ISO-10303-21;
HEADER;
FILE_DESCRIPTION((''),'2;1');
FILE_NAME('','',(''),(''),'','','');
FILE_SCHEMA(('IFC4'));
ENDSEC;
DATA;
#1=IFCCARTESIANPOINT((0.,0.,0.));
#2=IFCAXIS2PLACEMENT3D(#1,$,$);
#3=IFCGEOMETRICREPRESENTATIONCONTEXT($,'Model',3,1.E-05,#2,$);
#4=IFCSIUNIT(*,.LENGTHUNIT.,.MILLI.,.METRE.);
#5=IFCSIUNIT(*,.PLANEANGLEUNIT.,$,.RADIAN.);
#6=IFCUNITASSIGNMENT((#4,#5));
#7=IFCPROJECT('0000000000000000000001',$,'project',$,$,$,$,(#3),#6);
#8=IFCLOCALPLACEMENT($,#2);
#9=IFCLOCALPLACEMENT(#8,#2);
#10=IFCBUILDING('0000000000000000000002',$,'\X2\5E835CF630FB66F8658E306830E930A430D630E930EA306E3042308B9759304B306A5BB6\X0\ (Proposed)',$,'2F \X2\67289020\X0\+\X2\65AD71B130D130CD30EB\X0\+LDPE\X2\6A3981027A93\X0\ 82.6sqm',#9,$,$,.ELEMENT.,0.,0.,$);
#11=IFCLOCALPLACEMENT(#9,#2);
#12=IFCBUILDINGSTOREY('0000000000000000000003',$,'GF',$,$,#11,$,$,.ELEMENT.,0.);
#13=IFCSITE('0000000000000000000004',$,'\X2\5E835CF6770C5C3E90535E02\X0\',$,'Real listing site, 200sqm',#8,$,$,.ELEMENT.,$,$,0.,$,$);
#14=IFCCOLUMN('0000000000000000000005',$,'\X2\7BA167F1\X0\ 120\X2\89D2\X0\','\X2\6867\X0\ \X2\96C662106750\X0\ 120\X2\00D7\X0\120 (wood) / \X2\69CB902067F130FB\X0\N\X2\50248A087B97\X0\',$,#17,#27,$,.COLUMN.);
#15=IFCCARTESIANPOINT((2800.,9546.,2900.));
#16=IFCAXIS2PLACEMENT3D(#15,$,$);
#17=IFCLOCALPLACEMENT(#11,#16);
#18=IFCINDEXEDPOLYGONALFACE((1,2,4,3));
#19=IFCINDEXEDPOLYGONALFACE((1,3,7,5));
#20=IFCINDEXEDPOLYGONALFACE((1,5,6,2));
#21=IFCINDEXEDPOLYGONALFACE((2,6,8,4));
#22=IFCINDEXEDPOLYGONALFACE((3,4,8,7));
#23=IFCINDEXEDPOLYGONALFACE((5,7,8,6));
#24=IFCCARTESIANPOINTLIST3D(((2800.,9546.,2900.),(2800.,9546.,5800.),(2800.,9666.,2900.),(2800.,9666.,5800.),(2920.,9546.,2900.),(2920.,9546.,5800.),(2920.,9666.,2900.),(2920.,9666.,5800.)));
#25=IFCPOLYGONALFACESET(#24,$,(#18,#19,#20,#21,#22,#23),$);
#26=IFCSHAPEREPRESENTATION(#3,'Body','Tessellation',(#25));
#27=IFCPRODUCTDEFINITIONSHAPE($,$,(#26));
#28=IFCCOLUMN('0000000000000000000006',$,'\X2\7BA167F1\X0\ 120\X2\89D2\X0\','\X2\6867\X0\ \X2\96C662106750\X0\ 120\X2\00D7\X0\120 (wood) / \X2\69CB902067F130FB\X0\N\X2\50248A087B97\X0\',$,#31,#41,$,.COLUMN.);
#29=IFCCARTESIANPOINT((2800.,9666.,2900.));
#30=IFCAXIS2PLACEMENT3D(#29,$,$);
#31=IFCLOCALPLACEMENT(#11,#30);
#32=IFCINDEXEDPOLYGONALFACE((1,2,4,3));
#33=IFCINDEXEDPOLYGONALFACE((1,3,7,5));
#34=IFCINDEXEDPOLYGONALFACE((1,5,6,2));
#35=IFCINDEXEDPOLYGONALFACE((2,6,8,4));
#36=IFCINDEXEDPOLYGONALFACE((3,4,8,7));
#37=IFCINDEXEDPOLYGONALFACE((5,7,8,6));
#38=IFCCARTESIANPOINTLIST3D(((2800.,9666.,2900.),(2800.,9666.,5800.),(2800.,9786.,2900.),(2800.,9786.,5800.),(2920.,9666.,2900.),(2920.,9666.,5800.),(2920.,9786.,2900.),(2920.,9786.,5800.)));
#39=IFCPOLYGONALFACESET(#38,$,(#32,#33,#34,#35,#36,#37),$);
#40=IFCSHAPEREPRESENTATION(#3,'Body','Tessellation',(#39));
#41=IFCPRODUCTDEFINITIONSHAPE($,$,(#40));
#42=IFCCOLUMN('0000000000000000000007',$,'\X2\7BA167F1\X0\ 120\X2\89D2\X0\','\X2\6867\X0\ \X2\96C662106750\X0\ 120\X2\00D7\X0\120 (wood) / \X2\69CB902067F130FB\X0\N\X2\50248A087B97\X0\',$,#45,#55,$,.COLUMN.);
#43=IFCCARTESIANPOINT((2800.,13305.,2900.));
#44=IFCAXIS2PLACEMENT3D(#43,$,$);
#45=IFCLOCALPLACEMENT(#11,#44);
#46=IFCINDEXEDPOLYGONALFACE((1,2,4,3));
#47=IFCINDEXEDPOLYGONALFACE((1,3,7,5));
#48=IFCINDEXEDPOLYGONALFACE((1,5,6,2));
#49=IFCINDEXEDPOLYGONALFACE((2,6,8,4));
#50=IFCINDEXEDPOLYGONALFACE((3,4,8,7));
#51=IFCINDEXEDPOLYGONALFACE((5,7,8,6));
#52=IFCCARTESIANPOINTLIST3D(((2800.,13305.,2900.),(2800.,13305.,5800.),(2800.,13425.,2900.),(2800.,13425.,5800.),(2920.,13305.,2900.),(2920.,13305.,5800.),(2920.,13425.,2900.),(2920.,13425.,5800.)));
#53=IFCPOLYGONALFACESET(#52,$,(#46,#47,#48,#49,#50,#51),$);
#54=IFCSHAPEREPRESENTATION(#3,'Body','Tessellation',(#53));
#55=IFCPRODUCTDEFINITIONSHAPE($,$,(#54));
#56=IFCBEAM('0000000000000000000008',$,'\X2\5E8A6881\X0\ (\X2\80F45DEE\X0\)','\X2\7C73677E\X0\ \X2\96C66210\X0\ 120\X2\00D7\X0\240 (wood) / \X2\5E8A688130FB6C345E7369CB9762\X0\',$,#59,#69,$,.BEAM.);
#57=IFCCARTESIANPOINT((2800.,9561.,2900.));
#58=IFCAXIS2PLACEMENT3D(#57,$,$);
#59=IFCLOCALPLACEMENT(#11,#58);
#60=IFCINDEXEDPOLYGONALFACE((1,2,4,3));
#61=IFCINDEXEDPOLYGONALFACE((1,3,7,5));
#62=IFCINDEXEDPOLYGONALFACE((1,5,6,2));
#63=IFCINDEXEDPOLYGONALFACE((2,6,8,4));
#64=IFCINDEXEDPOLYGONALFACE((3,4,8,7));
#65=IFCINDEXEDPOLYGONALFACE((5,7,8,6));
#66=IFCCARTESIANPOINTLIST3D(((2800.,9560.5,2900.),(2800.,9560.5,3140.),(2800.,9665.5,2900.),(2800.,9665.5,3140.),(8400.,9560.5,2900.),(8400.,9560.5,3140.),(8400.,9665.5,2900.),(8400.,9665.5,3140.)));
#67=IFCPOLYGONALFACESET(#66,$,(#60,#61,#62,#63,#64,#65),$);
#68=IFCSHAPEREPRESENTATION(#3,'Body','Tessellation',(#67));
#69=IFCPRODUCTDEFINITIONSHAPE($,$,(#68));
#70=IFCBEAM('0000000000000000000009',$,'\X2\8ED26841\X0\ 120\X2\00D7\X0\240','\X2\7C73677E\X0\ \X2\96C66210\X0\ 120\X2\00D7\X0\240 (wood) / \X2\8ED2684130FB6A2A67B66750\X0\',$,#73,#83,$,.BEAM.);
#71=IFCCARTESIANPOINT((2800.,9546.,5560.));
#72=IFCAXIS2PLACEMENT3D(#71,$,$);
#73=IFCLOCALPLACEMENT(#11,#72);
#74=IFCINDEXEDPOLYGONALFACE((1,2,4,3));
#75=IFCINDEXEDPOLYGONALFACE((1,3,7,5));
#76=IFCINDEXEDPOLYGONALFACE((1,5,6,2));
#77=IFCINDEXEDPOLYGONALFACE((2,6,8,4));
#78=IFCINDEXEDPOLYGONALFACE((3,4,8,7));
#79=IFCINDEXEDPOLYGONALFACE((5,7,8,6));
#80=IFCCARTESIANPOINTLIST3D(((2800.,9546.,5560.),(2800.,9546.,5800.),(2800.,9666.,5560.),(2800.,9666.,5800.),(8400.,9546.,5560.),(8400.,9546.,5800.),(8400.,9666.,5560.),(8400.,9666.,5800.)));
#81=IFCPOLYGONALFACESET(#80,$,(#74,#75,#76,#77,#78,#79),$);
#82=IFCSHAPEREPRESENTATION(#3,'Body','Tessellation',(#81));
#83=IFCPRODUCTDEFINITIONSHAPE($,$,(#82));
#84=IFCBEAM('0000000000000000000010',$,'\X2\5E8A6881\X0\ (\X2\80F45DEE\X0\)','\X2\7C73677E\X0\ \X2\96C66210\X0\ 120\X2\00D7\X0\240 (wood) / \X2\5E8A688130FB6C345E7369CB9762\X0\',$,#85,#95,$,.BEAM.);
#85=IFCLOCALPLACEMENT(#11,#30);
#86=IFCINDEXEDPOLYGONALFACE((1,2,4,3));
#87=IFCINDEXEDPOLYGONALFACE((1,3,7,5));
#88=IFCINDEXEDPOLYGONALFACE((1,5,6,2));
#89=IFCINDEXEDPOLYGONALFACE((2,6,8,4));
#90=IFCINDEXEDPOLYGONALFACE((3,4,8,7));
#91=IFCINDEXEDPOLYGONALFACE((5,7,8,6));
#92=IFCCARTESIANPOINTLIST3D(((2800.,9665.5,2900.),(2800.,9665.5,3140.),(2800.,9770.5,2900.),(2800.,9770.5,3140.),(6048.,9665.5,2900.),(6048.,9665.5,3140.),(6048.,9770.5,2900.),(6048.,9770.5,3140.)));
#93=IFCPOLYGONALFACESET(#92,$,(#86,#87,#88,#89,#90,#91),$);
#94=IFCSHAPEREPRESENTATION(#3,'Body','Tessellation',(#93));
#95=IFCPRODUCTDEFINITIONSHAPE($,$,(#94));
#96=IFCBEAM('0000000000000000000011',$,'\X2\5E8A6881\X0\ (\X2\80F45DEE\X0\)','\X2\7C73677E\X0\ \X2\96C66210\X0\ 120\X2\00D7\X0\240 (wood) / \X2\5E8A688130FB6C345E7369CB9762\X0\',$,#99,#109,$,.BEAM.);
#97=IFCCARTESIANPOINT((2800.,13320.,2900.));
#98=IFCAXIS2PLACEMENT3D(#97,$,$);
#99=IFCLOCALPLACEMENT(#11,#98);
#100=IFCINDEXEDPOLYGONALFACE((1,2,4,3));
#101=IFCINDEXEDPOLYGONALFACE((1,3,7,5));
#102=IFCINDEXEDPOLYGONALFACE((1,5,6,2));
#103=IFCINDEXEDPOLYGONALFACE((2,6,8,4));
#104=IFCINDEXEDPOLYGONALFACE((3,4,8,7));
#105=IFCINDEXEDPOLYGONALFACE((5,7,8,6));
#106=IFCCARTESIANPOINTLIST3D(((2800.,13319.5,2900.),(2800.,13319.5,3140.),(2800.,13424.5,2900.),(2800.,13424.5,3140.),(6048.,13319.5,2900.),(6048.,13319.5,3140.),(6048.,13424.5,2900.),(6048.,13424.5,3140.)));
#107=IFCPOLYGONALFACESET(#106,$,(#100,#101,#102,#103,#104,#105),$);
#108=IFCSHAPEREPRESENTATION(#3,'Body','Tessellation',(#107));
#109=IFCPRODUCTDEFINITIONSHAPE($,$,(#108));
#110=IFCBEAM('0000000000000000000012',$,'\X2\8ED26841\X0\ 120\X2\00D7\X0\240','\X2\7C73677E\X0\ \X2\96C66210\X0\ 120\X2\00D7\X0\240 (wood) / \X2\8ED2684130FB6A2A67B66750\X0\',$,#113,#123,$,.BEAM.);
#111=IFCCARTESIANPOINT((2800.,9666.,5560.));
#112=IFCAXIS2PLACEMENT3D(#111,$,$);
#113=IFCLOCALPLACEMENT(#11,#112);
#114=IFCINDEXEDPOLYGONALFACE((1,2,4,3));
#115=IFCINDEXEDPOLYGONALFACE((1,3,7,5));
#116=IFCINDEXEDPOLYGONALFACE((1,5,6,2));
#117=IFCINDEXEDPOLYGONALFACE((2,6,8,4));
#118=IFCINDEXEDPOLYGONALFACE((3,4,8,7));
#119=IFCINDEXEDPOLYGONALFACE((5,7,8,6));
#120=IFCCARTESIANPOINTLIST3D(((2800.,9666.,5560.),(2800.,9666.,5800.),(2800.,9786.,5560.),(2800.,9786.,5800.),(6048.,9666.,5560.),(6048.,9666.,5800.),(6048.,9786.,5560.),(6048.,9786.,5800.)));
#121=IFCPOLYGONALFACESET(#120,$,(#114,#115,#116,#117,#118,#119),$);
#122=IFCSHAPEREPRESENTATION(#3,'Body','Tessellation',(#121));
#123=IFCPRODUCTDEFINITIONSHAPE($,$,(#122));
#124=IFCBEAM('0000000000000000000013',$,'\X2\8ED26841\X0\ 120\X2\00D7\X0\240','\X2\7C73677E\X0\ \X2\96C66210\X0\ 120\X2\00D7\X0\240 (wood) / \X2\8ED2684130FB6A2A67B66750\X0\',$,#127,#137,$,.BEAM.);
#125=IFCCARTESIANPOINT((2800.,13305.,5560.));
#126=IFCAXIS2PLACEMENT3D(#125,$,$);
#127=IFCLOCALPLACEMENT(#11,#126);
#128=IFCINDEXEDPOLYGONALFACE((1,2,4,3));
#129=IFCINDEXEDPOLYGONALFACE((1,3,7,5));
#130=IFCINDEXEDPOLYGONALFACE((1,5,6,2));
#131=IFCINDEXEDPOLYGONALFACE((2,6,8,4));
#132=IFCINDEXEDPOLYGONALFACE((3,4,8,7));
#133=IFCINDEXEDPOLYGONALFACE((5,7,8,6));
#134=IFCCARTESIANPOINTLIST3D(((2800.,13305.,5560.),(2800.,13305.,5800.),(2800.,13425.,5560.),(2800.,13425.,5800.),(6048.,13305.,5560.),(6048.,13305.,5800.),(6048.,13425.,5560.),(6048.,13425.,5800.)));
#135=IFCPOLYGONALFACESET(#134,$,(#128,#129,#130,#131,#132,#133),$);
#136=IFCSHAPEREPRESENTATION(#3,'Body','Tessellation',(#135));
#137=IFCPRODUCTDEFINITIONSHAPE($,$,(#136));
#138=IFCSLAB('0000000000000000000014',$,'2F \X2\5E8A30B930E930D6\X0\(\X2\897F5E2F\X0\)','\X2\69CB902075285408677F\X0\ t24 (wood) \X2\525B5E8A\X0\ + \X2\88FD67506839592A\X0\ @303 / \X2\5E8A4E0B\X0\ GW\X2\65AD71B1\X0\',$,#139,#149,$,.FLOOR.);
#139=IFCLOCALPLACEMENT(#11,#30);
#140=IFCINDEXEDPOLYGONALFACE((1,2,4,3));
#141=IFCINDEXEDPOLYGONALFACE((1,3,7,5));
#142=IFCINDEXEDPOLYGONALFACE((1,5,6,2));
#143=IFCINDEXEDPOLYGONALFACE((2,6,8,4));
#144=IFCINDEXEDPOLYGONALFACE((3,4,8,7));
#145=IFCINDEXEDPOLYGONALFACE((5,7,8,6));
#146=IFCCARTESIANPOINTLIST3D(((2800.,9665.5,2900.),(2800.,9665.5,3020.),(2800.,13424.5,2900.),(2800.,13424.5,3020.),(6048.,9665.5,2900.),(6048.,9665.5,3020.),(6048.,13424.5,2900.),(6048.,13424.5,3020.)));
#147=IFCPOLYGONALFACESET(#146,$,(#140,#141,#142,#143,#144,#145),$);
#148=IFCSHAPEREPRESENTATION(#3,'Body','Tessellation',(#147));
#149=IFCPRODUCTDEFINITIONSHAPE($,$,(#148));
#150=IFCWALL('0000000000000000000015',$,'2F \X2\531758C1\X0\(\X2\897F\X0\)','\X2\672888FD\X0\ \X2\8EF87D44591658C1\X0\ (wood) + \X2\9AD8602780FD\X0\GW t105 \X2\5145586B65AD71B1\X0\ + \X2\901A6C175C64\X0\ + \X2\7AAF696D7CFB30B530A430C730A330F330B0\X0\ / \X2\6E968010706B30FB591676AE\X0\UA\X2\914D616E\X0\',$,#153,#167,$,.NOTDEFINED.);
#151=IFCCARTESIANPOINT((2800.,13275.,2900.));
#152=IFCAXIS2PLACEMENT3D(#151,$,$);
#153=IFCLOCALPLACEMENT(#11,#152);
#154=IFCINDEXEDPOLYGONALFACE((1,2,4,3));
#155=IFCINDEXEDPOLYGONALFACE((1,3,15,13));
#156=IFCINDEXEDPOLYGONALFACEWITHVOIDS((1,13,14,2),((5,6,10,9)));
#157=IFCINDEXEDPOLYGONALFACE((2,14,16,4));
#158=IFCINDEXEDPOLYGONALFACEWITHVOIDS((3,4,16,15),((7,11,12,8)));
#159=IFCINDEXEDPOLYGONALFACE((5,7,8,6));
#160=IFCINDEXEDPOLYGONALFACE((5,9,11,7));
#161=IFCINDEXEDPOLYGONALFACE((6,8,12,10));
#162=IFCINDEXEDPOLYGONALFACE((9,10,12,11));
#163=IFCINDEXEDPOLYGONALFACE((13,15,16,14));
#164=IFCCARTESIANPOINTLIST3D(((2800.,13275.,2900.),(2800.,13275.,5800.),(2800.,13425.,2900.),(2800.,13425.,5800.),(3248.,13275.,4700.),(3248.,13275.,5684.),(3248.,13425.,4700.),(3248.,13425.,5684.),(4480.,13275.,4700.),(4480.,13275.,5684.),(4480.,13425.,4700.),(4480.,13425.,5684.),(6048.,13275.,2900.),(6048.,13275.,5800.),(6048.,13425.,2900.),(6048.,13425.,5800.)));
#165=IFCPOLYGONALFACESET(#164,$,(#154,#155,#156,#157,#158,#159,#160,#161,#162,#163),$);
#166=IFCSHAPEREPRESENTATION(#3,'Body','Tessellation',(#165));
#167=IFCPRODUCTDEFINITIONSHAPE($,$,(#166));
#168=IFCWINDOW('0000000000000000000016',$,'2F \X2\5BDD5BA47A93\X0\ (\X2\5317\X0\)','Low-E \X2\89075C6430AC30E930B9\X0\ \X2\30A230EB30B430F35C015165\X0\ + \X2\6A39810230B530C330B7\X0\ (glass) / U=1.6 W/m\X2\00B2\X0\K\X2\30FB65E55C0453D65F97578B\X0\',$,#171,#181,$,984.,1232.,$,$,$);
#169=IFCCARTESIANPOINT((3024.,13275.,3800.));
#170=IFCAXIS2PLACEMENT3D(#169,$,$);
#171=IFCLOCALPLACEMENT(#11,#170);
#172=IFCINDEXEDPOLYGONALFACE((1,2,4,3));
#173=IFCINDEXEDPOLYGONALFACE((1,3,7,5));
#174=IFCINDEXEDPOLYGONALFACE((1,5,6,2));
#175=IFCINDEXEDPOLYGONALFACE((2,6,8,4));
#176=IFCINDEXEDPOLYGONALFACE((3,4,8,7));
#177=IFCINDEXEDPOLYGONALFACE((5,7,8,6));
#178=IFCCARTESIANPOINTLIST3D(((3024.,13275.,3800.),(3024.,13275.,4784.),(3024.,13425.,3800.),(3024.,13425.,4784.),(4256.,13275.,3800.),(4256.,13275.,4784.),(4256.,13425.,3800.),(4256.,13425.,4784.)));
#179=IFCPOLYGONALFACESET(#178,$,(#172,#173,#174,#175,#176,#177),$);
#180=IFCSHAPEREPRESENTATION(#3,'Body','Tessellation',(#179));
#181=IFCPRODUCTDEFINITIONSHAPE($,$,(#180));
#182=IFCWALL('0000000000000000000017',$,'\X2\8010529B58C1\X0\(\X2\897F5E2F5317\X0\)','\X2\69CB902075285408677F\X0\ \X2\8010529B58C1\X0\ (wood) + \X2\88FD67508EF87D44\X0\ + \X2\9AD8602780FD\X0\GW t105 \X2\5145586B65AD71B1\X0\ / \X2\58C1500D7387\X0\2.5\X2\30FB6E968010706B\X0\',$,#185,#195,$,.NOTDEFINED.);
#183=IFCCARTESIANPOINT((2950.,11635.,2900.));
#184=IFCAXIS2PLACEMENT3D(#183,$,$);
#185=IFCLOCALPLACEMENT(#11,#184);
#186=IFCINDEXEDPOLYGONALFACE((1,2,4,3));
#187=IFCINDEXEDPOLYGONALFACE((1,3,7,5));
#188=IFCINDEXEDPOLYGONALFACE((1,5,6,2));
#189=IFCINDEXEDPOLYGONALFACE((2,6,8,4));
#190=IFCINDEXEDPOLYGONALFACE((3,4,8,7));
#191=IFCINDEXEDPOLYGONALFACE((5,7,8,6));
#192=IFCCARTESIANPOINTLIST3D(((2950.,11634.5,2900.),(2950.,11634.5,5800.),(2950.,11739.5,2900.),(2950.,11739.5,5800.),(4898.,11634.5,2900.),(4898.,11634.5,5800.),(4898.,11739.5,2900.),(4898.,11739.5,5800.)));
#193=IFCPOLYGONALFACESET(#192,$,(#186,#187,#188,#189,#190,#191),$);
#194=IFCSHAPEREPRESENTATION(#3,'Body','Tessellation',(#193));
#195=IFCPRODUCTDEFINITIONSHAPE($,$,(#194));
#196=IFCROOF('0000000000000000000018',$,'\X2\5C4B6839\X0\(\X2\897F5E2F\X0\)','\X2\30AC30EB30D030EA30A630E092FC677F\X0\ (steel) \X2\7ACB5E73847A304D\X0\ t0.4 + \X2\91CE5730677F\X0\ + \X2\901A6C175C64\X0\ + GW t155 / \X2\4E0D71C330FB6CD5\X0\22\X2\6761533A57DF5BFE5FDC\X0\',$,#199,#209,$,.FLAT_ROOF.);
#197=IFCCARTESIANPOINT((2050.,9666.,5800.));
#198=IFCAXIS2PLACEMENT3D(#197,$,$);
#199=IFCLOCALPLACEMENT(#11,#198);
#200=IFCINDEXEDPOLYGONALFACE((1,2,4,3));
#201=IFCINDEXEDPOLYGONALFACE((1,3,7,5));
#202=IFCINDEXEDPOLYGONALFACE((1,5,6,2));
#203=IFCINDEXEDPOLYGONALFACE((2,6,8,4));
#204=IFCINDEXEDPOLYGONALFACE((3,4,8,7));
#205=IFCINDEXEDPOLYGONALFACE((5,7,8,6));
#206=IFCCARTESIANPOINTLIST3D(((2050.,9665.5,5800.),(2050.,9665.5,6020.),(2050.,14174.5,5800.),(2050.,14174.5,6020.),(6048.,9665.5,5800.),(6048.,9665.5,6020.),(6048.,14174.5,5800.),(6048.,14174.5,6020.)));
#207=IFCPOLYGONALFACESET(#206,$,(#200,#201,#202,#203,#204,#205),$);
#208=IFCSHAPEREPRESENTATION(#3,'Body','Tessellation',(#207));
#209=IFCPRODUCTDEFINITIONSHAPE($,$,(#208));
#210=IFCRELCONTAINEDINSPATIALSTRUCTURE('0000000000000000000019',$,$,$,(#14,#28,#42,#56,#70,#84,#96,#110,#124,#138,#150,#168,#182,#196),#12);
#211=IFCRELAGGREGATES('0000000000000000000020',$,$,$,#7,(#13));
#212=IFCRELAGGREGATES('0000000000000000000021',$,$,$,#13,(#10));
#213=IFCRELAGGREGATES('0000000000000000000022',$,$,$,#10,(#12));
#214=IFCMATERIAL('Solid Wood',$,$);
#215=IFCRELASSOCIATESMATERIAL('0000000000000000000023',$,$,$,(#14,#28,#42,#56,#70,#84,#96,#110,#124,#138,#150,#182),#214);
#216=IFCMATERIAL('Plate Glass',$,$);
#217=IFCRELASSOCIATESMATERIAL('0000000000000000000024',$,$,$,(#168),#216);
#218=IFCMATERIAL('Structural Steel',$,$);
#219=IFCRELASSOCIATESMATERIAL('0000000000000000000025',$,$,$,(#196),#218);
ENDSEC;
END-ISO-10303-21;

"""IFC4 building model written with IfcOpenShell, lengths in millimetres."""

from ifc_helpers import new_model, si_unit, frame, frame_2d, origin, place, context, project, spatial, rectangle, extrude, material, element, fill, save


model = new_model("IFC4")

# Units and contexts
model_context = context("Model", 3, precision=1e-05, world=origin())
ifc_project = project(units=[si_unit("LENGTHUNIT", "METRE", prefix="MILLI"), si_unit("PLANEANGLEUNIT", "RADIAN")], contexts=[model_context])

# Site, building, storey
site_placement = place(None, origin())
site = spatial("IfcSite", under=ifc_project, at=site_placement, Name="広島県尾道市", ObjectType="Real listing site, 200sqm", CompositionType="ELEMENT", RefElevation=0.0)
building_placement = place(site_placement, origin())
building = spatial("IfcBuilding", under=site, at=building_placement, Name="広島・書斎とライブラリのある静かな家 (Proposed)", ObjectType="2F 木造+断熱パネル+LDPE樹脂窓 82.6sqm", CompositionType="ELEMENT", ElevationOfRefHeight=0.0, ElevationOfTerrain=0.0)
storey_placement = place(building_placement, origin())
storey = spatial("IfcBuildingStorey", under=building, at=storey_placement, Name="GF", CompositionType="ELEMENT", Elevation=0.0)

# Columns
ifc_material_1 = material(Name="Solid Wood")
column_1_placement = place(storey_placement, frame((2800.0, 9546.0, 2900.0)))
element("IfcColumn", 1, at=column_1_placement, inside=storey, material=ifc_material_1, Name="管柱 120角", Description="桧 集成材 120×120 (wood) / 構造柱・N値計算", PredefinedType="COLUMN", context=model_context, shape_type="SweptSolid", body=[
    extrude(rectangle(XDim=120.0, YDim=120.0, at=frame_2d((60.0, 60.0))), frame((2800.0, 9546.0, 2900.0)), (0.0, 0.0, 1.0), 2900.0),
])
column_2_placement = place(storey_placement, frame((2800.0, 9666.0, 2900.0)))
element("IfcColumn", 2, at=column_2_placement, inside=storey, material=ifc_material_1, Name="管柱 120角", Description="桧 集成材 120×120 (wood) / 構造柱・N値計算", PredefinedType="COLUMN", context=model_context, shape_type="SweptSolid", body=[
    extrude(rectangle(XDim=120.0, YDim=120.0, at=frame_2d((60.0, 60.0))), frame((2800.0, 9666.0, 2900.0)), (0.0, 0.0, 1.0), 2900.0),
])
column_3_placement = place(storey_placement, frame((2800.0, 13305.0, 2900.0)))
element("IfcColumn", 3, at=column_3_placement, inside=storey, material=ifc_material_1, Name="管柱 120角", Description="桧 集成材 120×120 (wood) / 構造柱・N値計算", PredefinedType="COLUMN", context=model_context, shape_type="SweptSolid", body=[
    extrude(rectangle(XDim=120.0, YDim=120.0, at=frame_2d((60.0, 60.0))), frame((2800.0, 13305.0, 2900.0)), (0.0, 0.0, 1.0), 2900.0),
])

# Beams
beam_1_placement = place(storey_placement, frame((2800.0, 9561.0, 2900.0)))
element("IfcBeam", 4, at=beam_1_placement, inside=storey, material=ifc_material_1, Name="床梁 (胴差)", Description="米松 集成 120×240 (wood) / 床梁・水平構面", PredefinedType="BEAM", context=model_context, shape_type="SweptSolid", body=[
    extrude(rectangle(XDim=5600.0, YDim=105.0, at=frame_2d((2800.0, 52.0))), frame((2800.0, 9561.0, 2900.0)), (0.0, 0.0, 1.0), 240.0),
])
beam_2_placement = place(storey_placement, frame((2800.0, 9546.0, 5560.0)))
element("IfcBeam", 5, at=beam_2_placement, inside=storey, material=ifc_material_1, Name="軒桁 120×240", Description="米松 集成 120×240 (wood) / 軒桁・横架材", PredefinedType="BEAM", context=model_context, shape_type="SweptSolid", body=[
    extrude(rectangle(XDim=5600.0, YDim=120.0, at=frame_2d((2800.0, 60.0))), frame((2800.0, 9546.0, 5560.0)), (0.0, 0.0, 1.0), 240.0),
])
beam_3_placement = place(storey_placement, frame((2800.0, 9666.0, 2900.0)))
element("IfcBeam", 6, at=beam_3_placement, inside=storey, material=ifc_material_1, Name="床梁 (胴差)", Description="米松 集成 120×240 (wood) / 床梁・水平構面", PredefinedType="BEAM", context=model_context, shape_type="SweptSolid", body=[
    extrude(rectangle(XDim=3248.0, YDim=105.0, at=frame_2d((1624.0, 52.0))), frame((2800.0, 9666.0, 2900.0)), (0.0, 0.0, 1.0), 240.0),
])
beam_4_placement = place(storey_placement, frame((2800.0, 13320.0, 2900.0)))
element("IfcBeam", 7, at=beam_4_placement, inside=storey, material=ifc_material_1, Name="床梁 (胴差)", Description="米松 集成 120×240 (wood) / 床梁・水平構面", PredefinedType="BEAM", context=model_context, shape_type="SweptSolid", body=[
    extrude(rectangle(XDim=3248.0, YDim=105.0, at=frame_2d((1624.0, 52.0))), frame((2800.0, 13320.0, 2900.0)), (0.0, 0.0, 1.0), 240.0),
])
beam_5_placement = place(storey_placement, frame((2800.0, 9666.0, 5560.0)))
element("IfcBeam", 8, at=beam_5_placement, inside=storey, material=ifc_material_1, Name="軒桁 120×240", Description="米松 集成 120×240 (wood) / 軒桁・横架材", PredefinedType="BEAM", context=model_context, shape_type="SweptSolid", body=[
    extrude(rectangle(XDim=3248.0, YDim=120.0, at=frame_2d((1624.0, 60.0))), frame((2800.0, 9666.0, 5560.0)), (0.0, 0.0, 1.0), 240.0),
])
beam_6_placement = place(storey_placement, frame((2800.0, 13305.0, 5560.0)))
element("IfcBeam", 9, at=beam_6_placement, inside=storey, material=ifc_material_1, Name="軒桁 120×240", Description="米松 集成 120×240 (wood) / 軒桁・横架材", PredefinedType="BEAM", context=model_context, shape_type="SweptSolid", body=[
    extrude(rectangle(XDim=3248.0, YDim=120.0, at=frame_2d((1624.0, 60.0))), frame((2800.0, 13305.0, 5560.0)), (0.0, 0.0, 1.0), 240.0),
])

# Slab
slab_placement = place(storey_placement, frame((2800.0, 9666.0, 2900.0)))
element("IfcSlab", 10, at=slab_placement, inside=storey, material=ifc_material_1, Name="2F 床スラブ(西帯)", Description="構造用合板 t24 (wood) 剛床 + 製材根太 @303 / 床下 GW断熱", PredefinedType="FLOOR", context=model_context, shape_type="SweptSolid", body=[
    extrude(rectangle(XDim=3248.0, YDim=3759.0, at=frame_2d((1624.0, 1879.0))), frame((2800.0, 9666.0, 2900.0)), (0.0, 0.0, 1.0), 120.0),
])

# Wall, opening, window
wall_1_placement = place(storey_placement, frame((2800.0, 13275.0, 2900.0)))
wall_1 = element("IfcWall", 11, at=wall_1_placement, inside=storey, material=ifc_material_1, Name="2F 北壁(西)", Description="木製 軸組外壁 (wood) + 高性能GW t105 充填断熱 + 通気層 + 窯業系サイディング / 準耐火・外皮UA配慮", PredefinedType="NOTDEFINED", context=model_context, shape_type="SweptSolid", body=[
    extrude(rectangle(XDim=3248.0, YDim=150.0, at=frame_2d((1624.0, 75.0))), frame((2800.0, 13275.0, 2900.0)), (0.0, 0.0, 1.0), 2900.0),
])
opening_placement = place(storey_placement, frame((3024.0, 13275.0, 3800.0)))
opening = element("IfcOpeningElement", 12, at=opening_placement, cuts=wall_1, PredefinedType="NOTDEFINED", context=model_context, shape_type="SweptSolid", body=[
    extrude(rectangle(XDim=1232.0, YDim=150.0, at=frame_2d((616.0, 75.0))), frame((3024.0, 13275.0, 3800.0)), (0.0, 0.0, 1.0), 984.0),
])
ifc_material_2 = material(Name="Plate Glass")
window_placement = place(storey_placement, frame((3024.0, 13275.0, 3800.0)))
window = element("IfcWindow", 13, at=window_placement, inside=storey, material=ifc_material_2, Name="2F 寝室窓 (北)", Description="Low-E 複層ガラス アルゴン封入 + 樹脂サッシ (glass) / U=1.6 W/m²K・日射取得型", OverallHeight=984.0, OverallWidth=1232.0, context=model_context, shape_type="SweptSolid", body=[
    extrude(rectangle(XDim=1232.0, YDim=150.0, at=frame_2d((616.0, 75.0))), frame((3024.0, 13275.0, 3800.0)), (0.0, 0.0, 1.0), 984.0),
])
fill(opening, window)

# Wall
wall_2_placement = place(storey_placement, frame((2950.0, 11635.0, 2900.0)))
element("IfcWall", 14, at=wall_2_placement, inside=storey, material=ifc_material_1, Name="耐力壁(西帯北)", Description="構造用合板 耐力壁 (wood) + 製材軸組 + 高性能GW t105 充填断熱 / 壁倍率2.5・準耐火", PredefinedType="NOTDEFINED", context=model_context, shape_type="SweptSolid", body=[
    extrude(rectangle(XDim=1948.0, YDim=105.0, at=frame_2d((974.0, 52.0))), frame((2950.0, 11635.0, 2900.0)), (0.0, 0.0, 1.0), 2900.0),
])

# Roof
ifc_material_3 = material(Name="Structural Steel")
for number, where, name in (
    (15, (2050.0, 9666.0, 5800.0), "屋根(西帯)"),
):
    element("IfcRoof", number, at=place(storey_placement, frame(where)), inside=storey, material=ifc_material_3, Name=name, Description="ガルバリウム鋼板 (steel) 立平葺き t0.4 + 野地板 + 通気層 + GW t155 / 不燃・法22条区域対応", PredefinedType="FLAT_ROOF", context=model_context, shape_type="SweptSolid", body=[
        extrude(rectangle(XDim=3998.0, YDim=4509.0, at=frame_2d((1999.0, 2254.0))), frame((2050.0, 9666.0, 5800.0)), (0.0, 0.0, 1.0), 220.0),
    ])

save(model, "model.ifc")
